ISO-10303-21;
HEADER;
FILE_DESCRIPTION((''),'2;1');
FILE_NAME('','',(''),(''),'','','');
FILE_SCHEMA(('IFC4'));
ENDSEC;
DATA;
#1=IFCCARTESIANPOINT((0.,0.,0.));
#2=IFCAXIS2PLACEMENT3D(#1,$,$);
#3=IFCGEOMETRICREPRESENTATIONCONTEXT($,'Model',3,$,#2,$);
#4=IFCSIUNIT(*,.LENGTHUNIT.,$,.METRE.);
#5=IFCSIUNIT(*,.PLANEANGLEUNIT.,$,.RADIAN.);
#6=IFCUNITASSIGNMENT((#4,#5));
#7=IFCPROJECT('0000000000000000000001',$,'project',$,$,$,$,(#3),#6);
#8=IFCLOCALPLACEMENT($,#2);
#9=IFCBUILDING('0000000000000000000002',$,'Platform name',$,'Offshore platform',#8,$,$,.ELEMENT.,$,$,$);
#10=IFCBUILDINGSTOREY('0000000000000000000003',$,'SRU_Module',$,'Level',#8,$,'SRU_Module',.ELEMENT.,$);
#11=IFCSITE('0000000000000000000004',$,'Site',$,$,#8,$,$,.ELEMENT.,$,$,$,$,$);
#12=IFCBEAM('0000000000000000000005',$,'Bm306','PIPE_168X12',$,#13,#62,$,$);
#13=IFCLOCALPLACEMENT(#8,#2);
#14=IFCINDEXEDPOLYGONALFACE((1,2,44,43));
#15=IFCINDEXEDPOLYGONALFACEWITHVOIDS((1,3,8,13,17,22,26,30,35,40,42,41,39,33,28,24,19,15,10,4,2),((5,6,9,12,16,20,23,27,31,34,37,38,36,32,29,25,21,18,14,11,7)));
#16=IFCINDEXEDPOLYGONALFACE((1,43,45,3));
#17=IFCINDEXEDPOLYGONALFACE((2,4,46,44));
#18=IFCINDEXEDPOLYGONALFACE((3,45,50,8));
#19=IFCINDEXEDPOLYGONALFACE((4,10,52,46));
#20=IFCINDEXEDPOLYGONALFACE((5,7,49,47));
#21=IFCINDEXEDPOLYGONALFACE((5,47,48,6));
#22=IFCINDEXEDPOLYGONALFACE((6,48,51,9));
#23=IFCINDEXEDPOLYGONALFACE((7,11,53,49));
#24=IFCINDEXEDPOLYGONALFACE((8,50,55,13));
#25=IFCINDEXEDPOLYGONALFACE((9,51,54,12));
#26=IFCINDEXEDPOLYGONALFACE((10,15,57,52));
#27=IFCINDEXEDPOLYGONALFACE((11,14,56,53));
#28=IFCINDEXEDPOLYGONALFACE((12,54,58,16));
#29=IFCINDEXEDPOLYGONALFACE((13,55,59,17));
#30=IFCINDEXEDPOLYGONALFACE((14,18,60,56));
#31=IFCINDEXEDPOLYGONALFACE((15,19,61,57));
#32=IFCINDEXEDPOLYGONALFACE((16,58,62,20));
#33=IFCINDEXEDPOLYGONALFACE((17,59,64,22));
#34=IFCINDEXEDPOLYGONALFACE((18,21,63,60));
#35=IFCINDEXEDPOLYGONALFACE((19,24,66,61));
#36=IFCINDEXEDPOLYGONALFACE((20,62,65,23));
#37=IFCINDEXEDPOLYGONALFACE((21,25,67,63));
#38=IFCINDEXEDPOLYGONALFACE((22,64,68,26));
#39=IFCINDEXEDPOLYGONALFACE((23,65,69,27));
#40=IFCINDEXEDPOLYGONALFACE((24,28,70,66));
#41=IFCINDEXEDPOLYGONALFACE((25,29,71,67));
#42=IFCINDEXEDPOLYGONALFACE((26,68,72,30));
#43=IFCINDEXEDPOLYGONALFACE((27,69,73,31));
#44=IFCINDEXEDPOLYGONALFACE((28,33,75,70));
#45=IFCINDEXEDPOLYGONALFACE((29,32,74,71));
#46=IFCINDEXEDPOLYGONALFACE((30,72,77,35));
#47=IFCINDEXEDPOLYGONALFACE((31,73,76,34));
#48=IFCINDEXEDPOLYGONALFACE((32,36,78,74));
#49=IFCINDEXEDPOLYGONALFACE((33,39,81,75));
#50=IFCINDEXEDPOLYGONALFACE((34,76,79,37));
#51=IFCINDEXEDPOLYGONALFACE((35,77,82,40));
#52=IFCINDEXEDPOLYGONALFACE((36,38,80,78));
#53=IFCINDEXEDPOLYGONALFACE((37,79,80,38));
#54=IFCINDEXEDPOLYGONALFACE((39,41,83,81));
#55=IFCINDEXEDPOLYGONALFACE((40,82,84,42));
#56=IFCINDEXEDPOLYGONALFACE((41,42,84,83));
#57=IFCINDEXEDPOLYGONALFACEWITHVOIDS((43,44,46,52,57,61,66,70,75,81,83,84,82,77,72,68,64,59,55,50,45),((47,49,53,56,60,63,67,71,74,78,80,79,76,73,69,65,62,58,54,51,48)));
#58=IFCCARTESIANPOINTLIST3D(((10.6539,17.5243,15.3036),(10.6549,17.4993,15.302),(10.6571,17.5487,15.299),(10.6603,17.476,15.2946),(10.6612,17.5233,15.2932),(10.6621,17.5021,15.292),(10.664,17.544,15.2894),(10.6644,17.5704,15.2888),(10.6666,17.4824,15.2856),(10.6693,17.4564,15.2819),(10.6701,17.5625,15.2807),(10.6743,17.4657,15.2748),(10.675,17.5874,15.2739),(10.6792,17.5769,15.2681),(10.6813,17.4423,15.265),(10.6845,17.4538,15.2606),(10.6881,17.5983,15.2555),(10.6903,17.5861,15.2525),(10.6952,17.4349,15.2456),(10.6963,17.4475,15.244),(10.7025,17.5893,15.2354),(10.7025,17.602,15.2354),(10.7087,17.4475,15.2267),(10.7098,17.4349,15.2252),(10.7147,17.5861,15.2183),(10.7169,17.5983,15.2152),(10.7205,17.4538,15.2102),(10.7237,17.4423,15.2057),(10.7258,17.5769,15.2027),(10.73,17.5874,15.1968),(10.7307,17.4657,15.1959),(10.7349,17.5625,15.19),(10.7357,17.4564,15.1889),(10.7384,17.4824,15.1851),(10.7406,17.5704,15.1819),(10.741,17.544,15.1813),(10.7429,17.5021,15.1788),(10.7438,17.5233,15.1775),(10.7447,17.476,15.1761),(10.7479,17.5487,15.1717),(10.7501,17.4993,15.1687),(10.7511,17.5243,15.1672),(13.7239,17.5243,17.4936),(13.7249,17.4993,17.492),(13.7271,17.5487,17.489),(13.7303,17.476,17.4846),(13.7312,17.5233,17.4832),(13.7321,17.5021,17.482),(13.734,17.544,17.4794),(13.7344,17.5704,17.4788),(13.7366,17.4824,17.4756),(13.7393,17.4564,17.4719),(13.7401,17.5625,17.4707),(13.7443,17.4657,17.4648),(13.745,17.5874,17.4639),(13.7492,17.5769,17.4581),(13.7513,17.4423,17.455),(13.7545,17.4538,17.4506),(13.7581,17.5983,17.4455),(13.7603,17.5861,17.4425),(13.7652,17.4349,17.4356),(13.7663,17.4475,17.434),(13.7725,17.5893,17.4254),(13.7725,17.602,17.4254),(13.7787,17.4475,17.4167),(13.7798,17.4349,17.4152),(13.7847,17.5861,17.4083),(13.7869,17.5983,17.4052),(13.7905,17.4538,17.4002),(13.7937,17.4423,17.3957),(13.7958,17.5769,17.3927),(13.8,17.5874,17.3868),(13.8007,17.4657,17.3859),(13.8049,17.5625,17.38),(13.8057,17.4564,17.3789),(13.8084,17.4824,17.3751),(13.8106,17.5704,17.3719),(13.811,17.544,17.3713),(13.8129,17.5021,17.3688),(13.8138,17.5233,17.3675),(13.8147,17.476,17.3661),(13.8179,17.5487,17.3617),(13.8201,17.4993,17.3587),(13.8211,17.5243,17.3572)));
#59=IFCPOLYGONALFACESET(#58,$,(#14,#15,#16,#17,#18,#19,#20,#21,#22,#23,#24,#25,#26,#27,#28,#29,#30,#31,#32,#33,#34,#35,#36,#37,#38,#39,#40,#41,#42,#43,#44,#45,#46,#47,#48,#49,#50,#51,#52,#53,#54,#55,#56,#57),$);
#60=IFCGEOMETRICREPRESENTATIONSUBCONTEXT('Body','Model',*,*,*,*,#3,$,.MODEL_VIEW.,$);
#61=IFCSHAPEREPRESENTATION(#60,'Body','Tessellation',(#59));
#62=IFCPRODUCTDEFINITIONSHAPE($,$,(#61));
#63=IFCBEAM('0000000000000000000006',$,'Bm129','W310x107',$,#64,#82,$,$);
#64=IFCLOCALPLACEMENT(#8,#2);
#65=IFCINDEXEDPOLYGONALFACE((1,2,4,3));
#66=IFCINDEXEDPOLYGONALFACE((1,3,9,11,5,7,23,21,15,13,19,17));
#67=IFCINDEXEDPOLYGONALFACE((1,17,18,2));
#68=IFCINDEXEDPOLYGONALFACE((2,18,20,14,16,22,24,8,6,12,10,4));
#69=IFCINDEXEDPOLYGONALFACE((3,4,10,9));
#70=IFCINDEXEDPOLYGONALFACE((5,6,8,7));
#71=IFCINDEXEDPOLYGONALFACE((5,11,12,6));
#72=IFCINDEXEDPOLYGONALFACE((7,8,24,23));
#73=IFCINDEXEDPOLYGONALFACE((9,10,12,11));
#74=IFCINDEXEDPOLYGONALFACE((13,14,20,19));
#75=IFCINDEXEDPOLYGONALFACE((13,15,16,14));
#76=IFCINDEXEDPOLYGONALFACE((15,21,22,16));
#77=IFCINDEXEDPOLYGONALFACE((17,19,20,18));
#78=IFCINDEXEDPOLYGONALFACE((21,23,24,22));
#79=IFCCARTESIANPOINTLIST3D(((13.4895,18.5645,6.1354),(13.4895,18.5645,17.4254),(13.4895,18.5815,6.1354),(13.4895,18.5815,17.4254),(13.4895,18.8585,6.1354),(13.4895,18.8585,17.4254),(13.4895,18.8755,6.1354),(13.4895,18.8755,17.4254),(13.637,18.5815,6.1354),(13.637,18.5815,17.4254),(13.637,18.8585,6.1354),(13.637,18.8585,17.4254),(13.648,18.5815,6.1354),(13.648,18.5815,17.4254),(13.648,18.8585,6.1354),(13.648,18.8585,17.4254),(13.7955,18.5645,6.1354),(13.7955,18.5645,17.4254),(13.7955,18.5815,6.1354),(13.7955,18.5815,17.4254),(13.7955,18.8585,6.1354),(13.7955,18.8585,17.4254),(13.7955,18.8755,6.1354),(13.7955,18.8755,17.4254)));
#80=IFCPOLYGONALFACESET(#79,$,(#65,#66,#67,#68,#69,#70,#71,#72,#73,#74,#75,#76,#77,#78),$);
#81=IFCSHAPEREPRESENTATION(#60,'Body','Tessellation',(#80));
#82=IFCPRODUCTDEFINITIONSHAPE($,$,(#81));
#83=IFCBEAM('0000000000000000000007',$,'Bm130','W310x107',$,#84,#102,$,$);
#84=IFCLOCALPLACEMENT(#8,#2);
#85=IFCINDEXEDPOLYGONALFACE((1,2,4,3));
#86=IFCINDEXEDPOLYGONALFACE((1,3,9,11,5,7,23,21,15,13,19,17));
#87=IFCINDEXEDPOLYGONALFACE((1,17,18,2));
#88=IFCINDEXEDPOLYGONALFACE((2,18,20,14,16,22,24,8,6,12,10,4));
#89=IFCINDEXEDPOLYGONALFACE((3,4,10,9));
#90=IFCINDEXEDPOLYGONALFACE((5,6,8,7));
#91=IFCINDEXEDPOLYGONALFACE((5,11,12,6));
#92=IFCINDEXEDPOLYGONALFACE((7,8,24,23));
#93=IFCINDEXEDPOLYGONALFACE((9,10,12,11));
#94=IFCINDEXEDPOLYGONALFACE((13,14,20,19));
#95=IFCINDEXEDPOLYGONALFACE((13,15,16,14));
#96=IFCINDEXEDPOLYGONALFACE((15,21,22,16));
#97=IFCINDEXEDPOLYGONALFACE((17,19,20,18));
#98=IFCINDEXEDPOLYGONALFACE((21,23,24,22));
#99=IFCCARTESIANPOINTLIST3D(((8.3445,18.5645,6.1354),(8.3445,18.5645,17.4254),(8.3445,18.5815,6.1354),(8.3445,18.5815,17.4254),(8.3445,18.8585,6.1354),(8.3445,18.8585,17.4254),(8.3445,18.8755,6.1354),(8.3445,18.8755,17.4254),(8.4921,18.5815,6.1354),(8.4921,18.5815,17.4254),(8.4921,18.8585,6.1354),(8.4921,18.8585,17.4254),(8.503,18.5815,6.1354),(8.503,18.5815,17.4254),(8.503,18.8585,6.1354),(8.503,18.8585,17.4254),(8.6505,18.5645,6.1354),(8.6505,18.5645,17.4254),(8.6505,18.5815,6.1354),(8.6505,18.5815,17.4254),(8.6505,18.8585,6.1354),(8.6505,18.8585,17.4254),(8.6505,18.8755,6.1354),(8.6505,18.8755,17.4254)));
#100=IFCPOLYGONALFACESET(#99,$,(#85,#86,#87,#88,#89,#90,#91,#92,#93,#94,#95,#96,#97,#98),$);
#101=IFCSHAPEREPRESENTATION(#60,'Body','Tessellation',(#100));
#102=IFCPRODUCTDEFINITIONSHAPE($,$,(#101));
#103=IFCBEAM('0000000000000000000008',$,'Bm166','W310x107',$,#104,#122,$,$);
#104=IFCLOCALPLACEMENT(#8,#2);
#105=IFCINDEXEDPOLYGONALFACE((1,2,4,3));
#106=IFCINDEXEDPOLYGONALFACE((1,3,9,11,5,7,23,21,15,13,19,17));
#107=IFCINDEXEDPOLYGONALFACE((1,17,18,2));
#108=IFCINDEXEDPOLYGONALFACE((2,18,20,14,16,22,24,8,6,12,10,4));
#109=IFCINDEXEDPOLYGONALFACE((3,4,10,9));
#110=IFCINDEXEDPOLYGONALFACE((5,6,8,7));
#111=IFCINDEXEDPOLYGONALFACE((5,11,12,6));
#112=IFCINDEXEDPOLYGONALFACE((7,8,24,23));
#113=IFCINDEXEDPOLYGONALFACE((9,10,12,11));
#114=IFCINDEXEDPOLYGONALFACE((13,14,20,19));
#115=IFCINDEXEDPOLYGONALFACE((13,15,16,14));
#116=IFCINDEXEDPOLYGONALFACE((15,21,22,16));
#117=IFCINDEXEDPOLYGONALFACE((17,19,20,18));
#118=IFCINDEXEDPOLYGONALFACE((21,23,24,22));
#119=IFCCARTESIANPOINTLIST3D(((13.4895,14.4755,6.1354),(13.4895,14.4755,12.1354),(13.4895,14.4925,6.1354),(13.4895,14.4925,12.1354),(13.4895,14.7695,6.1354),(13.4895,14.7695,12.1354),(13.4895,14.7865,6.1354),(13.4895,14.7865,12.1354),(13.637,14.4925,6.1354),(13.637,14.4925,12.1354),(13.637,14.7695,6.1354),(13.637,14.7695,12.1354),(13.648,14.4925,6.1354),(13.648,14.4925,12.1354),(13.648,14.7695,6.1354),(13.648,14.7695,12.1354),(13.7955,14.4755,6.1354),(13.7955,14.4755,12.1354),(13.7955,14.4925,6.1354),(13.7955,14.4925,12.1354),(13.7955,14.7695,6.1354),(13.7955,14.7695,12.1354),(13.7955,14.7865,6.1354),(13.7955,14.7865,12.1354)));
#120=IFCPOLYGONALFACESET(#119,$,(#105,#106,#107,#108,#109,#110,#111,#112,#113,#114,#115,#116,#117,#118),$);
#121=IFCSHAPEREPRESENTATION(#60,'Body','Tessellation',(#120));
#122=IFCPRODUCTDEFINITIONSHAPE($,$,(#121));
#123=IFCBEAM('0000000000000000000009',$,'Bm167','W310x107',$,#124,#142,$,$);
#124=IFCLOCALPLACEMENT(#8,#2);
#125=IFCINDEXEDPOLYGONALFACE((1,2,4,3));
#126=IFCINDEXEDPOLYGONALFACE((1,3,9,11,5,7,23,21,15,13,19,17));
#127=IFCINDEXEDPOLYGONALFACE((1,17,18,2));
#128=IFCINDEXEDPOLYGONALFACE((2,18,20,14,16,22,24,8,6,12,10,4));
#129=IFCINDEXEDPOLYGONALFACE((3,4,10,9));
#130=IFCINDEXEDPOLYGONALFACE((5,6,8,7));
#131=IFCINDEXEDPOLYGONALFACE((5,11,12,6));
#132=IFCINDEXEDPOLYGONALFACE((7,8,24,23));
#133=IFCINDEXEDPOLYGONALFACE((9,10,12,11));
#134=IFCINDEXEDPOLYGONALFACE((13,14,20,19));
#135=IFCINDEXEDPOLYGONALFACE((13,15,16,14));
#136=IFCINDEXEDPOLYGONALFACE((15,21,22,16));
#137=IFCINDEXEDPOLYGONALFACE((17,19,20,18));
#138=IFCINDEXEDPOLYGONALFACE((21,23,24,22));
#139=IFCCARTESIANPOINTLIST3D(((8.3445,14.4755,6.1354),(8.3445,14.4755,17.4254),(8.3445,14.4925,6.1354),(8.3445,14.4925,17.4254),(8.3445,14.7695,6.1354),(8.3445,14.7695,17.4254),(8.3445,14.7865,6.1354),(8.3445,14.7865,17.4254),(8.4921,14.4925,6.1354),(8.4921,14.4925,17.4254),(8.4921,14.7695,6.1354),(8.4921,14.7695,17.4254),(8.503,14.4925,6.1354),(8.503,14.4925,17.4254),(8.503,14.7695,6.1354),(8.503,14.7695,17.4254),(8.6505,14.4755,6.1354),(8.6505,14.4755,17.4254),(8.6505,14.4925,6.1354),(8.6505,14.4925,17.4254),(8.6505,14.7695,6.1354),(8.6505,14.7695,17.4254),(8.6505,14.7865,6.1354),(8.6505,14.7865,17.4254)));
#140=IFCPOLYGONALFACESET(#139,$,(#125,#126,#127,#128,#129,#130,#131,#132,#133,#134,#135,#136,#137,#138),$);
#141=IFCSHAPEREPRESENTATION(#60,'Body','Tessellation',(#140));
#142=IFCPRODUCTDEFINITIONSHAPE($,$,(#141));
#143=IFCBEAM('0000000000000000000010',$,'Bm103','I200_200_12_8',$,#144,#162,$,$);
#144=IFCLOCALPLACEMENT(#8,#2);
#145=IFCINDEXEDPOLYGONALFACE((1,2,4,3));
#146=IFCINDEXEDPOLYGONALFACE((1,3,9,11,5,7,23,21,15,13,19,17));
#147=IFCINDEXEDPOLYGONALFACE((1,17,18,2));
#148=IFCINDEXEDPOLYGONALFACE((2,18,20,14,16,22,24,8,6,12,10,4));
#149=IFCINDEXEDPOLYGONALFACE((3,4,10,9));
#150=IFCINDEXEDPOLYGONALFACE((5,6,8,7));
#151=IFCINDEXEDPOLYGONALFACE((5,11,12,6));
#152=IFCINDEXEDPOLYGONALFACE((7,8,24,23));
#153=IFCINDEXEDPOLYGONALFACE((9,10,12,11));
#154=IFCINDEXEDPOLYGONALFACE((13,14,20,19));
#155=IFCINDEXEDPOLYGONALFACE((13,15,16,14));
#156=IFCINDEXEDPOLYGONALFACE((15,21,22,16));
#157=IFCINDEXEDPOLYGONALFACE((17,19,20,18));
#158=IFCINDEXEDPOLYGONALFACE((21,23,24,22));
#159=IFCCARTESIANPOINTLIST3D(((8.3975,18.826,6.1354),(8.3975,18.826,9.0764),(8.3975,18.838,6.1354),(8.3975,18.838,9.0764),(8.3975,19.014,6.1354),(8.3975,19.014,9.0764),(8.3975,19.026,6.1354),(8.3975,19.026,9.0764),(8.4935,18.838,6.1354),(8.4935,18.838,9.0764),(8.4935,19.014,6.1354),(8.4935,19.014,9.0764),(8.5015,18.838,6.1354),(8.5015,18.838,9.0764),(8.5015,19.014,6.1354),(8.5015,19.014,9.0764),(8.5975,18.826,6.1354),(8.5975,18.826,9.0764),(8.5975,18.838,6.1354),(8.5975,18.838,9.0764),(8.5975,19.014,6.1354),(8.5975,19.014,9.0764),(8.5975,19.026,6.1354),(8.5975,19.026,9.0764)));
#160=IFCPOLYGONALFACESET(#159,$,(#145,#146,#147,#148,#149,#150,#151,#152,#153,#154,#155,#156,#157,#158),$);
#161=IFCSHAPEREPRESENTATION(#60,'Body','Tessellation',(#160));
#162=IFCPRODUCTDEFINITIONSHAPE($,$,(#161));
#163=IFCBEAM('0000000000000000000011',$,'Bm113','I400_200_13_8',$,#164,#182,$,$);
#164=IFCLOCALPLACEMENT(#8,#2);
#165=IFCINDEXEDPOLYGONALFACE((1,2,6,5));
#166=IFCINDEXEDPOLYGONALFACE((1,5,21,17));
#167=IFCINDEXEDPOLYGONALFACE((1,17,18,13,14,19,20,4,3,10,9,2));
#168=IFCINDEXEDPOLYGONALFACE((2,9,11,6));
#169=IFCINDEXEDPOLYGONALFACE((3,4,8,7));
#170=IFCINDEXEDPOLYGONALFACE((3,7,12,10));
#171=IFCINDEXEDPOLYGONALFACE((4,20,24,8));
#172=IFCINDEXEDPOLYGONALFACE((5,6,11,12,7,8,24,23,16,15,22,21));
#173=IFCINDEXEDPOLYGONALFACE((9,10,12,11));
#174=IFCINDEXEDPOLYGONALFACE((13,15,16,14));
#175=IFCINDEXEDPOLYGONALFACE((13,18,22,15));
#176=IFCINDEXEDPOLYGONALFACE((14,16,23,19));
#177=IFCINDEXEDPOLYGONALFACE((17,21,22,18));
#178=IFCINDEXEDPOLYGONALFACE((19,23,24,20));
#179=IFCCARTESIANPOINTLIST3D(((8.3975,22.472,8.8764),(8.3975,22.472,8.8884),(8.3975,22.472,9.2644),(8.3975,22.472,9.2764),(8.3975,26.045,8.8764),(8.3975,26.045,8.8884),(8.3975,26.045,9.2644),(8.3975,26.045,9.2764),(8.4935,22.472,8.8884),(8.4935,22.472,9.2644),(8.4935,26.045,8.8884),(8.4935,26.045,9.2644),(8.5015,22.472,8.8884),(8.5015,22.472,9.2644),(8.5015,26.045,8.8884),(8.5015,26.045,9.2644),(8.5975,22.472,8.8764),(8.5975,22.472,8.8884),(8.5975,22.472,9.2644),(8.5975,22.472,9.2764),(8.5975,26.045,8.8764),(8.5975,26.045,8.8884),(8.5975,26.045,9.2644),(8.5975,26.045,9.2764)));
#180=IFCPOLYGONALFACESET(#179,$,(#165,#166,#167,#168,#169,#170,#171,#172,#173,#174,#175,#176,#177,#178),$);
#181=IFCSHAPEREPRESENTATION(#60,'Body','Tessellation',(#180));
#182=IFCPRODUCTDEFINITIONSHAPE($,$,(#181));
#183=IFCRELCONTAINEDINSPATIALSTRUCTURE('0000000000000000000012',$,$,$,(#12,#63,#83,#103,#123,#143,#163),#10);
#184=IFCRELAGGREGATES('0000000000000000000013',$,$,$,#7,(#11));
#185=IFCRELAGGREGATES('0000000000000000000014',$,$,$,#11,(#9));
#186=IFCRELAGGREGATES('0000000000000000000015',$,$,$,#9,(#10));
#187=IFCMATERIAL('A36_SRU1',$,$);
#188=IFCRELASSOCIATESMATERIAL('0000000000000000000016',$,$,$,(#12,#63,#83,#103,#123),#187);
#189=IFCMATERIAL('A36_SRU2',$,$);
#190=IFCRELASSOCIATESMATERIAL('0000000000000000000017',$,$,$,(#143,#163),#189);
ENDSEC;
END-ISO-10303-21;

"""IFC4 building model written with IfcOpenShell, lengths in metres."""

from ifc_helpers import new_model, si_unit, frame, origin, origin_with_axes, origin_2d, place, context, subcontext, project, spatial, hollow_circle, i_section, extrude, source, transform, mapped, material, element, save


model = new_model("IFC4")

# Units and contexts
model_context = context("Model", 3, world=origin())
body_context = subcontext(model_context, "Body", "Model", "MODEL_VIEW")
ifc_project = project(units=[si_unit("LENGTHUNIT", "METRE"), si_unit("PLANEANGLEUNIT", "RADIAN")], contexts=[model_context])

# Site, building, storey
placement_1 = place(None, origin())
site = spatial("IfcSite", under=ifc_project, at=placement_1, Name="Site", CompositionType="ELEMENT")
building = spatial("IfcBuilding", under=site, at=placement_1, Name="Platform name", ObjectType="Offshore platform", CompositionType="ELEMENT")
storey = spatial("IfcBuildingStorey", under=building, at=placement_1, Name="SRU_Module", ObjectType="Level", LongName="SRU_Module", CompositionType="ELEMENT")

# Beams
ifc_material_1 = material(Name="A36_SRU1")
shared_shape_1 = source(origin(), body_context, "Body", "SweptSolid", [
    extrude(hollow_circle(Radius=0.084, WallThickness=0.0127, at=origin_2d()), frame((0.0, 0.0, 0.0), z_axis=(0.814092, 0.0, 0.580736), x_axis=(0.0, 1.0, 0.0)), (0.0, 0.0, 1.0), 3.7711),
])
placement_2 = place(None, origin())
placement_3 = place(placement_2, origin())
placement_4 = place(placement_3, origin())
beam_1_placement = place(placement_4, frame((10.7025, 17.518, 15.2354)))
element("IfcBeam", 1, at=beam_1_placement, inside=storey, material=ifc_material_1, Name="Bm306", Description="PIPE_168X12", context=body_context, shape_type="MappedRepresentation", body=[
    mapped(shared_shape_1, transform((0.0, 0.0, 0.0), scale=1.0)),
])
shared_shape_2 = source(origin(), body_context, "Body", "SweptSolid", [
    extrude(i_section(OverallWidth=0.306, OverallDepth=0.311, WebThickness=0.0109, FlangeThickness=0.017, FilletRadius=0.0, at=origin_2d()), origin_with_axes(), (0.0, 0.0, 1.0), 11.29),
])
placement_5 = place(None, origin())
placement_6 = place(placement_5, origin())
placement_7 = place(placement_6, origin())
beam_2_placement = place(placement_7, frame((13.6425, 18.72, 6.1354)))
element("IfcBeam", 2, at=beam_2_placement, inside=storey, material=ifc_material_1, Name="Bm129", Description="W310x107", context=body_context, shape_type="MappedRepresentation", body=[
    mapped(shared_shape_2, transform((0.0, 0.0, 0.0), scale=1.0)),
])
shared_shape_3 = source(origin(), body_context, "Body", "SweptSolid", [
    extrude(i_section(OverallWidth=0.306, OverallDepth=0.311, WebThickness=0.0109, FlangeThickness=0.017, FilletRadius=0.0, at=origin_2d()), origin_with_axes(), (0.0, 0.0, 1.0), 11.29),
])
placement_8 = place(None, origin())
placement_9 = place(placement_8, origin())
placement_10 = place(placement_9, origin())
beam_3_placement = place(placement_10, frame((8.4975, 18.72, 6.1354)))
element("IfcBeam", 3, at=beam_3_placement, inside=storey, material=ifc_material_1, Name="Bm130", Description="W310x107", context=body_context, shape_type="MappedRepresentation", body=[
    mapped(shared_shape_3, transform((0.0, 0.0, 0.0), scale=1.0)),
])
shared_shape_4 = source(origin(), body_context, "Body", "SweptSolid", [
    extrude(i_section(OverallWidth=0.306, OverallDepth=0.311, WebThickness=0.0109, FlangeThickness=0.017, FilletRadius=0.0, at=origin_2d()), origin_with_axes(), (0.0, 0.0, 1.0), 6.0),
])
placement_11 = place(None, origin())
placement_12 = place(placement_11, origin())
placement_13 = place(placement_12, origin())
beam_4_placement = place(placement_13, frame((13.6425, 14.631, 6.1354)))
element("IfcBeam", 4, at=beam_4_placement, inside=storey, material=ifc_material_1, Name="Bm166", Description="W310x107", context=body_context, shape_type="MappedRepresentation", body=[
    mapped(shared_shape_4, transform((0.0, 0.0, 0.0), scale=1.0)),
])
shared_shape_5 = source(origin(), body_context, "Body", "SweptSolid", [
    extrude(i_section(OverallWidth=0.306, OverallDepth=0.311, WebThickness=0.0109, FlangeThickness=0.017, FilletRadius=0.0, at=origin_2d()), origin_with_axes(), (0.0, 0.0, 1.0), 11.29),
])
placement_14 = place(None, origin())
placement_15 = place(placement_14, origin())
placement_16 = place(placement_15, origin())
beam_5_placement = place(placement_16, frame((8.4975, 14.631, 6.1354)))
element("IfcBeam", 5, at=beam_5_placement, inside=storey, material=ifc_material_1, Name="Bm167", Description="W310x107", context=body_context, shape_type="MappedRepresentation", body=[
    mapped(shared_shape_5, transform((0.0, 0.0, 0.0), scale=1.0)),
])
ifc_material_2 = material(Name="A36_SRU2")
shared_shape_6 = source(origin(), body_context, "Body", "SweptSolid", [
    extrude(i_section(OverallWidth=0.2, OverallDepth=0.2, WebThickness=0.008, FlangeThickness=0.012, FilletRadius=0.0, at=origin_2d()), origin_with_axes(), (0.0, 0.0, 1.0), 2.941),
])
placement_17 = place(None, origin())
placement_18 = place(placement_17, origin())
placement_19 = place(placement_18, origin())
beam_6_placement = place(placement_19, frame((8.4975, 18.926, 6.1354)))
element("IfcBeam", 6, at=beam_6_placement, inside=storey, material=ifc_material_2, Name="Bm103", Description="I200_200_12_8", context=body_context, shape_type="MappedRepresentation", body=[
    mapped(shared_shape_6, transform((0.0, 0.0, 0.0), scale=1.0)),
])
shared_shape_7 = source(origin(), body_context, "Body", "SweptSolid", [
    extrude(i_section(OverallWidth=0.2, OverallDepth=0.4, WebThickness=0.008, FlangeThickness=0.012, FilletRadius=0.0, at=origin_2d()), frame((0.0, 0.0, 0.0), z_axis=(0.0, 1.0, 0.0), x_axis=(-1.0, 0.0, 0.0)), (0.0, 0.0, 1.0), 3.573),
])
placement_20 = place(None, origin())
placement_21 = place(placement_20, origin())
placement_22 = place(placement_21, origin())
beam_7_placement = place(placement_22, frame((8.4975, 22.472, 9.0764)))
element("IfcBeam", 7, at=beam_7_placement, inside=storey, material=ifc_material_2, Name="Bm113", Description="I400_200_13_8", context=body_context, shape_type="MappedRepresentation", body=[
    mapped(shared_shape_7, transform((0.0, 0.0, 0.0), scale=1.0)),
])

save(model, "model.ifc")
